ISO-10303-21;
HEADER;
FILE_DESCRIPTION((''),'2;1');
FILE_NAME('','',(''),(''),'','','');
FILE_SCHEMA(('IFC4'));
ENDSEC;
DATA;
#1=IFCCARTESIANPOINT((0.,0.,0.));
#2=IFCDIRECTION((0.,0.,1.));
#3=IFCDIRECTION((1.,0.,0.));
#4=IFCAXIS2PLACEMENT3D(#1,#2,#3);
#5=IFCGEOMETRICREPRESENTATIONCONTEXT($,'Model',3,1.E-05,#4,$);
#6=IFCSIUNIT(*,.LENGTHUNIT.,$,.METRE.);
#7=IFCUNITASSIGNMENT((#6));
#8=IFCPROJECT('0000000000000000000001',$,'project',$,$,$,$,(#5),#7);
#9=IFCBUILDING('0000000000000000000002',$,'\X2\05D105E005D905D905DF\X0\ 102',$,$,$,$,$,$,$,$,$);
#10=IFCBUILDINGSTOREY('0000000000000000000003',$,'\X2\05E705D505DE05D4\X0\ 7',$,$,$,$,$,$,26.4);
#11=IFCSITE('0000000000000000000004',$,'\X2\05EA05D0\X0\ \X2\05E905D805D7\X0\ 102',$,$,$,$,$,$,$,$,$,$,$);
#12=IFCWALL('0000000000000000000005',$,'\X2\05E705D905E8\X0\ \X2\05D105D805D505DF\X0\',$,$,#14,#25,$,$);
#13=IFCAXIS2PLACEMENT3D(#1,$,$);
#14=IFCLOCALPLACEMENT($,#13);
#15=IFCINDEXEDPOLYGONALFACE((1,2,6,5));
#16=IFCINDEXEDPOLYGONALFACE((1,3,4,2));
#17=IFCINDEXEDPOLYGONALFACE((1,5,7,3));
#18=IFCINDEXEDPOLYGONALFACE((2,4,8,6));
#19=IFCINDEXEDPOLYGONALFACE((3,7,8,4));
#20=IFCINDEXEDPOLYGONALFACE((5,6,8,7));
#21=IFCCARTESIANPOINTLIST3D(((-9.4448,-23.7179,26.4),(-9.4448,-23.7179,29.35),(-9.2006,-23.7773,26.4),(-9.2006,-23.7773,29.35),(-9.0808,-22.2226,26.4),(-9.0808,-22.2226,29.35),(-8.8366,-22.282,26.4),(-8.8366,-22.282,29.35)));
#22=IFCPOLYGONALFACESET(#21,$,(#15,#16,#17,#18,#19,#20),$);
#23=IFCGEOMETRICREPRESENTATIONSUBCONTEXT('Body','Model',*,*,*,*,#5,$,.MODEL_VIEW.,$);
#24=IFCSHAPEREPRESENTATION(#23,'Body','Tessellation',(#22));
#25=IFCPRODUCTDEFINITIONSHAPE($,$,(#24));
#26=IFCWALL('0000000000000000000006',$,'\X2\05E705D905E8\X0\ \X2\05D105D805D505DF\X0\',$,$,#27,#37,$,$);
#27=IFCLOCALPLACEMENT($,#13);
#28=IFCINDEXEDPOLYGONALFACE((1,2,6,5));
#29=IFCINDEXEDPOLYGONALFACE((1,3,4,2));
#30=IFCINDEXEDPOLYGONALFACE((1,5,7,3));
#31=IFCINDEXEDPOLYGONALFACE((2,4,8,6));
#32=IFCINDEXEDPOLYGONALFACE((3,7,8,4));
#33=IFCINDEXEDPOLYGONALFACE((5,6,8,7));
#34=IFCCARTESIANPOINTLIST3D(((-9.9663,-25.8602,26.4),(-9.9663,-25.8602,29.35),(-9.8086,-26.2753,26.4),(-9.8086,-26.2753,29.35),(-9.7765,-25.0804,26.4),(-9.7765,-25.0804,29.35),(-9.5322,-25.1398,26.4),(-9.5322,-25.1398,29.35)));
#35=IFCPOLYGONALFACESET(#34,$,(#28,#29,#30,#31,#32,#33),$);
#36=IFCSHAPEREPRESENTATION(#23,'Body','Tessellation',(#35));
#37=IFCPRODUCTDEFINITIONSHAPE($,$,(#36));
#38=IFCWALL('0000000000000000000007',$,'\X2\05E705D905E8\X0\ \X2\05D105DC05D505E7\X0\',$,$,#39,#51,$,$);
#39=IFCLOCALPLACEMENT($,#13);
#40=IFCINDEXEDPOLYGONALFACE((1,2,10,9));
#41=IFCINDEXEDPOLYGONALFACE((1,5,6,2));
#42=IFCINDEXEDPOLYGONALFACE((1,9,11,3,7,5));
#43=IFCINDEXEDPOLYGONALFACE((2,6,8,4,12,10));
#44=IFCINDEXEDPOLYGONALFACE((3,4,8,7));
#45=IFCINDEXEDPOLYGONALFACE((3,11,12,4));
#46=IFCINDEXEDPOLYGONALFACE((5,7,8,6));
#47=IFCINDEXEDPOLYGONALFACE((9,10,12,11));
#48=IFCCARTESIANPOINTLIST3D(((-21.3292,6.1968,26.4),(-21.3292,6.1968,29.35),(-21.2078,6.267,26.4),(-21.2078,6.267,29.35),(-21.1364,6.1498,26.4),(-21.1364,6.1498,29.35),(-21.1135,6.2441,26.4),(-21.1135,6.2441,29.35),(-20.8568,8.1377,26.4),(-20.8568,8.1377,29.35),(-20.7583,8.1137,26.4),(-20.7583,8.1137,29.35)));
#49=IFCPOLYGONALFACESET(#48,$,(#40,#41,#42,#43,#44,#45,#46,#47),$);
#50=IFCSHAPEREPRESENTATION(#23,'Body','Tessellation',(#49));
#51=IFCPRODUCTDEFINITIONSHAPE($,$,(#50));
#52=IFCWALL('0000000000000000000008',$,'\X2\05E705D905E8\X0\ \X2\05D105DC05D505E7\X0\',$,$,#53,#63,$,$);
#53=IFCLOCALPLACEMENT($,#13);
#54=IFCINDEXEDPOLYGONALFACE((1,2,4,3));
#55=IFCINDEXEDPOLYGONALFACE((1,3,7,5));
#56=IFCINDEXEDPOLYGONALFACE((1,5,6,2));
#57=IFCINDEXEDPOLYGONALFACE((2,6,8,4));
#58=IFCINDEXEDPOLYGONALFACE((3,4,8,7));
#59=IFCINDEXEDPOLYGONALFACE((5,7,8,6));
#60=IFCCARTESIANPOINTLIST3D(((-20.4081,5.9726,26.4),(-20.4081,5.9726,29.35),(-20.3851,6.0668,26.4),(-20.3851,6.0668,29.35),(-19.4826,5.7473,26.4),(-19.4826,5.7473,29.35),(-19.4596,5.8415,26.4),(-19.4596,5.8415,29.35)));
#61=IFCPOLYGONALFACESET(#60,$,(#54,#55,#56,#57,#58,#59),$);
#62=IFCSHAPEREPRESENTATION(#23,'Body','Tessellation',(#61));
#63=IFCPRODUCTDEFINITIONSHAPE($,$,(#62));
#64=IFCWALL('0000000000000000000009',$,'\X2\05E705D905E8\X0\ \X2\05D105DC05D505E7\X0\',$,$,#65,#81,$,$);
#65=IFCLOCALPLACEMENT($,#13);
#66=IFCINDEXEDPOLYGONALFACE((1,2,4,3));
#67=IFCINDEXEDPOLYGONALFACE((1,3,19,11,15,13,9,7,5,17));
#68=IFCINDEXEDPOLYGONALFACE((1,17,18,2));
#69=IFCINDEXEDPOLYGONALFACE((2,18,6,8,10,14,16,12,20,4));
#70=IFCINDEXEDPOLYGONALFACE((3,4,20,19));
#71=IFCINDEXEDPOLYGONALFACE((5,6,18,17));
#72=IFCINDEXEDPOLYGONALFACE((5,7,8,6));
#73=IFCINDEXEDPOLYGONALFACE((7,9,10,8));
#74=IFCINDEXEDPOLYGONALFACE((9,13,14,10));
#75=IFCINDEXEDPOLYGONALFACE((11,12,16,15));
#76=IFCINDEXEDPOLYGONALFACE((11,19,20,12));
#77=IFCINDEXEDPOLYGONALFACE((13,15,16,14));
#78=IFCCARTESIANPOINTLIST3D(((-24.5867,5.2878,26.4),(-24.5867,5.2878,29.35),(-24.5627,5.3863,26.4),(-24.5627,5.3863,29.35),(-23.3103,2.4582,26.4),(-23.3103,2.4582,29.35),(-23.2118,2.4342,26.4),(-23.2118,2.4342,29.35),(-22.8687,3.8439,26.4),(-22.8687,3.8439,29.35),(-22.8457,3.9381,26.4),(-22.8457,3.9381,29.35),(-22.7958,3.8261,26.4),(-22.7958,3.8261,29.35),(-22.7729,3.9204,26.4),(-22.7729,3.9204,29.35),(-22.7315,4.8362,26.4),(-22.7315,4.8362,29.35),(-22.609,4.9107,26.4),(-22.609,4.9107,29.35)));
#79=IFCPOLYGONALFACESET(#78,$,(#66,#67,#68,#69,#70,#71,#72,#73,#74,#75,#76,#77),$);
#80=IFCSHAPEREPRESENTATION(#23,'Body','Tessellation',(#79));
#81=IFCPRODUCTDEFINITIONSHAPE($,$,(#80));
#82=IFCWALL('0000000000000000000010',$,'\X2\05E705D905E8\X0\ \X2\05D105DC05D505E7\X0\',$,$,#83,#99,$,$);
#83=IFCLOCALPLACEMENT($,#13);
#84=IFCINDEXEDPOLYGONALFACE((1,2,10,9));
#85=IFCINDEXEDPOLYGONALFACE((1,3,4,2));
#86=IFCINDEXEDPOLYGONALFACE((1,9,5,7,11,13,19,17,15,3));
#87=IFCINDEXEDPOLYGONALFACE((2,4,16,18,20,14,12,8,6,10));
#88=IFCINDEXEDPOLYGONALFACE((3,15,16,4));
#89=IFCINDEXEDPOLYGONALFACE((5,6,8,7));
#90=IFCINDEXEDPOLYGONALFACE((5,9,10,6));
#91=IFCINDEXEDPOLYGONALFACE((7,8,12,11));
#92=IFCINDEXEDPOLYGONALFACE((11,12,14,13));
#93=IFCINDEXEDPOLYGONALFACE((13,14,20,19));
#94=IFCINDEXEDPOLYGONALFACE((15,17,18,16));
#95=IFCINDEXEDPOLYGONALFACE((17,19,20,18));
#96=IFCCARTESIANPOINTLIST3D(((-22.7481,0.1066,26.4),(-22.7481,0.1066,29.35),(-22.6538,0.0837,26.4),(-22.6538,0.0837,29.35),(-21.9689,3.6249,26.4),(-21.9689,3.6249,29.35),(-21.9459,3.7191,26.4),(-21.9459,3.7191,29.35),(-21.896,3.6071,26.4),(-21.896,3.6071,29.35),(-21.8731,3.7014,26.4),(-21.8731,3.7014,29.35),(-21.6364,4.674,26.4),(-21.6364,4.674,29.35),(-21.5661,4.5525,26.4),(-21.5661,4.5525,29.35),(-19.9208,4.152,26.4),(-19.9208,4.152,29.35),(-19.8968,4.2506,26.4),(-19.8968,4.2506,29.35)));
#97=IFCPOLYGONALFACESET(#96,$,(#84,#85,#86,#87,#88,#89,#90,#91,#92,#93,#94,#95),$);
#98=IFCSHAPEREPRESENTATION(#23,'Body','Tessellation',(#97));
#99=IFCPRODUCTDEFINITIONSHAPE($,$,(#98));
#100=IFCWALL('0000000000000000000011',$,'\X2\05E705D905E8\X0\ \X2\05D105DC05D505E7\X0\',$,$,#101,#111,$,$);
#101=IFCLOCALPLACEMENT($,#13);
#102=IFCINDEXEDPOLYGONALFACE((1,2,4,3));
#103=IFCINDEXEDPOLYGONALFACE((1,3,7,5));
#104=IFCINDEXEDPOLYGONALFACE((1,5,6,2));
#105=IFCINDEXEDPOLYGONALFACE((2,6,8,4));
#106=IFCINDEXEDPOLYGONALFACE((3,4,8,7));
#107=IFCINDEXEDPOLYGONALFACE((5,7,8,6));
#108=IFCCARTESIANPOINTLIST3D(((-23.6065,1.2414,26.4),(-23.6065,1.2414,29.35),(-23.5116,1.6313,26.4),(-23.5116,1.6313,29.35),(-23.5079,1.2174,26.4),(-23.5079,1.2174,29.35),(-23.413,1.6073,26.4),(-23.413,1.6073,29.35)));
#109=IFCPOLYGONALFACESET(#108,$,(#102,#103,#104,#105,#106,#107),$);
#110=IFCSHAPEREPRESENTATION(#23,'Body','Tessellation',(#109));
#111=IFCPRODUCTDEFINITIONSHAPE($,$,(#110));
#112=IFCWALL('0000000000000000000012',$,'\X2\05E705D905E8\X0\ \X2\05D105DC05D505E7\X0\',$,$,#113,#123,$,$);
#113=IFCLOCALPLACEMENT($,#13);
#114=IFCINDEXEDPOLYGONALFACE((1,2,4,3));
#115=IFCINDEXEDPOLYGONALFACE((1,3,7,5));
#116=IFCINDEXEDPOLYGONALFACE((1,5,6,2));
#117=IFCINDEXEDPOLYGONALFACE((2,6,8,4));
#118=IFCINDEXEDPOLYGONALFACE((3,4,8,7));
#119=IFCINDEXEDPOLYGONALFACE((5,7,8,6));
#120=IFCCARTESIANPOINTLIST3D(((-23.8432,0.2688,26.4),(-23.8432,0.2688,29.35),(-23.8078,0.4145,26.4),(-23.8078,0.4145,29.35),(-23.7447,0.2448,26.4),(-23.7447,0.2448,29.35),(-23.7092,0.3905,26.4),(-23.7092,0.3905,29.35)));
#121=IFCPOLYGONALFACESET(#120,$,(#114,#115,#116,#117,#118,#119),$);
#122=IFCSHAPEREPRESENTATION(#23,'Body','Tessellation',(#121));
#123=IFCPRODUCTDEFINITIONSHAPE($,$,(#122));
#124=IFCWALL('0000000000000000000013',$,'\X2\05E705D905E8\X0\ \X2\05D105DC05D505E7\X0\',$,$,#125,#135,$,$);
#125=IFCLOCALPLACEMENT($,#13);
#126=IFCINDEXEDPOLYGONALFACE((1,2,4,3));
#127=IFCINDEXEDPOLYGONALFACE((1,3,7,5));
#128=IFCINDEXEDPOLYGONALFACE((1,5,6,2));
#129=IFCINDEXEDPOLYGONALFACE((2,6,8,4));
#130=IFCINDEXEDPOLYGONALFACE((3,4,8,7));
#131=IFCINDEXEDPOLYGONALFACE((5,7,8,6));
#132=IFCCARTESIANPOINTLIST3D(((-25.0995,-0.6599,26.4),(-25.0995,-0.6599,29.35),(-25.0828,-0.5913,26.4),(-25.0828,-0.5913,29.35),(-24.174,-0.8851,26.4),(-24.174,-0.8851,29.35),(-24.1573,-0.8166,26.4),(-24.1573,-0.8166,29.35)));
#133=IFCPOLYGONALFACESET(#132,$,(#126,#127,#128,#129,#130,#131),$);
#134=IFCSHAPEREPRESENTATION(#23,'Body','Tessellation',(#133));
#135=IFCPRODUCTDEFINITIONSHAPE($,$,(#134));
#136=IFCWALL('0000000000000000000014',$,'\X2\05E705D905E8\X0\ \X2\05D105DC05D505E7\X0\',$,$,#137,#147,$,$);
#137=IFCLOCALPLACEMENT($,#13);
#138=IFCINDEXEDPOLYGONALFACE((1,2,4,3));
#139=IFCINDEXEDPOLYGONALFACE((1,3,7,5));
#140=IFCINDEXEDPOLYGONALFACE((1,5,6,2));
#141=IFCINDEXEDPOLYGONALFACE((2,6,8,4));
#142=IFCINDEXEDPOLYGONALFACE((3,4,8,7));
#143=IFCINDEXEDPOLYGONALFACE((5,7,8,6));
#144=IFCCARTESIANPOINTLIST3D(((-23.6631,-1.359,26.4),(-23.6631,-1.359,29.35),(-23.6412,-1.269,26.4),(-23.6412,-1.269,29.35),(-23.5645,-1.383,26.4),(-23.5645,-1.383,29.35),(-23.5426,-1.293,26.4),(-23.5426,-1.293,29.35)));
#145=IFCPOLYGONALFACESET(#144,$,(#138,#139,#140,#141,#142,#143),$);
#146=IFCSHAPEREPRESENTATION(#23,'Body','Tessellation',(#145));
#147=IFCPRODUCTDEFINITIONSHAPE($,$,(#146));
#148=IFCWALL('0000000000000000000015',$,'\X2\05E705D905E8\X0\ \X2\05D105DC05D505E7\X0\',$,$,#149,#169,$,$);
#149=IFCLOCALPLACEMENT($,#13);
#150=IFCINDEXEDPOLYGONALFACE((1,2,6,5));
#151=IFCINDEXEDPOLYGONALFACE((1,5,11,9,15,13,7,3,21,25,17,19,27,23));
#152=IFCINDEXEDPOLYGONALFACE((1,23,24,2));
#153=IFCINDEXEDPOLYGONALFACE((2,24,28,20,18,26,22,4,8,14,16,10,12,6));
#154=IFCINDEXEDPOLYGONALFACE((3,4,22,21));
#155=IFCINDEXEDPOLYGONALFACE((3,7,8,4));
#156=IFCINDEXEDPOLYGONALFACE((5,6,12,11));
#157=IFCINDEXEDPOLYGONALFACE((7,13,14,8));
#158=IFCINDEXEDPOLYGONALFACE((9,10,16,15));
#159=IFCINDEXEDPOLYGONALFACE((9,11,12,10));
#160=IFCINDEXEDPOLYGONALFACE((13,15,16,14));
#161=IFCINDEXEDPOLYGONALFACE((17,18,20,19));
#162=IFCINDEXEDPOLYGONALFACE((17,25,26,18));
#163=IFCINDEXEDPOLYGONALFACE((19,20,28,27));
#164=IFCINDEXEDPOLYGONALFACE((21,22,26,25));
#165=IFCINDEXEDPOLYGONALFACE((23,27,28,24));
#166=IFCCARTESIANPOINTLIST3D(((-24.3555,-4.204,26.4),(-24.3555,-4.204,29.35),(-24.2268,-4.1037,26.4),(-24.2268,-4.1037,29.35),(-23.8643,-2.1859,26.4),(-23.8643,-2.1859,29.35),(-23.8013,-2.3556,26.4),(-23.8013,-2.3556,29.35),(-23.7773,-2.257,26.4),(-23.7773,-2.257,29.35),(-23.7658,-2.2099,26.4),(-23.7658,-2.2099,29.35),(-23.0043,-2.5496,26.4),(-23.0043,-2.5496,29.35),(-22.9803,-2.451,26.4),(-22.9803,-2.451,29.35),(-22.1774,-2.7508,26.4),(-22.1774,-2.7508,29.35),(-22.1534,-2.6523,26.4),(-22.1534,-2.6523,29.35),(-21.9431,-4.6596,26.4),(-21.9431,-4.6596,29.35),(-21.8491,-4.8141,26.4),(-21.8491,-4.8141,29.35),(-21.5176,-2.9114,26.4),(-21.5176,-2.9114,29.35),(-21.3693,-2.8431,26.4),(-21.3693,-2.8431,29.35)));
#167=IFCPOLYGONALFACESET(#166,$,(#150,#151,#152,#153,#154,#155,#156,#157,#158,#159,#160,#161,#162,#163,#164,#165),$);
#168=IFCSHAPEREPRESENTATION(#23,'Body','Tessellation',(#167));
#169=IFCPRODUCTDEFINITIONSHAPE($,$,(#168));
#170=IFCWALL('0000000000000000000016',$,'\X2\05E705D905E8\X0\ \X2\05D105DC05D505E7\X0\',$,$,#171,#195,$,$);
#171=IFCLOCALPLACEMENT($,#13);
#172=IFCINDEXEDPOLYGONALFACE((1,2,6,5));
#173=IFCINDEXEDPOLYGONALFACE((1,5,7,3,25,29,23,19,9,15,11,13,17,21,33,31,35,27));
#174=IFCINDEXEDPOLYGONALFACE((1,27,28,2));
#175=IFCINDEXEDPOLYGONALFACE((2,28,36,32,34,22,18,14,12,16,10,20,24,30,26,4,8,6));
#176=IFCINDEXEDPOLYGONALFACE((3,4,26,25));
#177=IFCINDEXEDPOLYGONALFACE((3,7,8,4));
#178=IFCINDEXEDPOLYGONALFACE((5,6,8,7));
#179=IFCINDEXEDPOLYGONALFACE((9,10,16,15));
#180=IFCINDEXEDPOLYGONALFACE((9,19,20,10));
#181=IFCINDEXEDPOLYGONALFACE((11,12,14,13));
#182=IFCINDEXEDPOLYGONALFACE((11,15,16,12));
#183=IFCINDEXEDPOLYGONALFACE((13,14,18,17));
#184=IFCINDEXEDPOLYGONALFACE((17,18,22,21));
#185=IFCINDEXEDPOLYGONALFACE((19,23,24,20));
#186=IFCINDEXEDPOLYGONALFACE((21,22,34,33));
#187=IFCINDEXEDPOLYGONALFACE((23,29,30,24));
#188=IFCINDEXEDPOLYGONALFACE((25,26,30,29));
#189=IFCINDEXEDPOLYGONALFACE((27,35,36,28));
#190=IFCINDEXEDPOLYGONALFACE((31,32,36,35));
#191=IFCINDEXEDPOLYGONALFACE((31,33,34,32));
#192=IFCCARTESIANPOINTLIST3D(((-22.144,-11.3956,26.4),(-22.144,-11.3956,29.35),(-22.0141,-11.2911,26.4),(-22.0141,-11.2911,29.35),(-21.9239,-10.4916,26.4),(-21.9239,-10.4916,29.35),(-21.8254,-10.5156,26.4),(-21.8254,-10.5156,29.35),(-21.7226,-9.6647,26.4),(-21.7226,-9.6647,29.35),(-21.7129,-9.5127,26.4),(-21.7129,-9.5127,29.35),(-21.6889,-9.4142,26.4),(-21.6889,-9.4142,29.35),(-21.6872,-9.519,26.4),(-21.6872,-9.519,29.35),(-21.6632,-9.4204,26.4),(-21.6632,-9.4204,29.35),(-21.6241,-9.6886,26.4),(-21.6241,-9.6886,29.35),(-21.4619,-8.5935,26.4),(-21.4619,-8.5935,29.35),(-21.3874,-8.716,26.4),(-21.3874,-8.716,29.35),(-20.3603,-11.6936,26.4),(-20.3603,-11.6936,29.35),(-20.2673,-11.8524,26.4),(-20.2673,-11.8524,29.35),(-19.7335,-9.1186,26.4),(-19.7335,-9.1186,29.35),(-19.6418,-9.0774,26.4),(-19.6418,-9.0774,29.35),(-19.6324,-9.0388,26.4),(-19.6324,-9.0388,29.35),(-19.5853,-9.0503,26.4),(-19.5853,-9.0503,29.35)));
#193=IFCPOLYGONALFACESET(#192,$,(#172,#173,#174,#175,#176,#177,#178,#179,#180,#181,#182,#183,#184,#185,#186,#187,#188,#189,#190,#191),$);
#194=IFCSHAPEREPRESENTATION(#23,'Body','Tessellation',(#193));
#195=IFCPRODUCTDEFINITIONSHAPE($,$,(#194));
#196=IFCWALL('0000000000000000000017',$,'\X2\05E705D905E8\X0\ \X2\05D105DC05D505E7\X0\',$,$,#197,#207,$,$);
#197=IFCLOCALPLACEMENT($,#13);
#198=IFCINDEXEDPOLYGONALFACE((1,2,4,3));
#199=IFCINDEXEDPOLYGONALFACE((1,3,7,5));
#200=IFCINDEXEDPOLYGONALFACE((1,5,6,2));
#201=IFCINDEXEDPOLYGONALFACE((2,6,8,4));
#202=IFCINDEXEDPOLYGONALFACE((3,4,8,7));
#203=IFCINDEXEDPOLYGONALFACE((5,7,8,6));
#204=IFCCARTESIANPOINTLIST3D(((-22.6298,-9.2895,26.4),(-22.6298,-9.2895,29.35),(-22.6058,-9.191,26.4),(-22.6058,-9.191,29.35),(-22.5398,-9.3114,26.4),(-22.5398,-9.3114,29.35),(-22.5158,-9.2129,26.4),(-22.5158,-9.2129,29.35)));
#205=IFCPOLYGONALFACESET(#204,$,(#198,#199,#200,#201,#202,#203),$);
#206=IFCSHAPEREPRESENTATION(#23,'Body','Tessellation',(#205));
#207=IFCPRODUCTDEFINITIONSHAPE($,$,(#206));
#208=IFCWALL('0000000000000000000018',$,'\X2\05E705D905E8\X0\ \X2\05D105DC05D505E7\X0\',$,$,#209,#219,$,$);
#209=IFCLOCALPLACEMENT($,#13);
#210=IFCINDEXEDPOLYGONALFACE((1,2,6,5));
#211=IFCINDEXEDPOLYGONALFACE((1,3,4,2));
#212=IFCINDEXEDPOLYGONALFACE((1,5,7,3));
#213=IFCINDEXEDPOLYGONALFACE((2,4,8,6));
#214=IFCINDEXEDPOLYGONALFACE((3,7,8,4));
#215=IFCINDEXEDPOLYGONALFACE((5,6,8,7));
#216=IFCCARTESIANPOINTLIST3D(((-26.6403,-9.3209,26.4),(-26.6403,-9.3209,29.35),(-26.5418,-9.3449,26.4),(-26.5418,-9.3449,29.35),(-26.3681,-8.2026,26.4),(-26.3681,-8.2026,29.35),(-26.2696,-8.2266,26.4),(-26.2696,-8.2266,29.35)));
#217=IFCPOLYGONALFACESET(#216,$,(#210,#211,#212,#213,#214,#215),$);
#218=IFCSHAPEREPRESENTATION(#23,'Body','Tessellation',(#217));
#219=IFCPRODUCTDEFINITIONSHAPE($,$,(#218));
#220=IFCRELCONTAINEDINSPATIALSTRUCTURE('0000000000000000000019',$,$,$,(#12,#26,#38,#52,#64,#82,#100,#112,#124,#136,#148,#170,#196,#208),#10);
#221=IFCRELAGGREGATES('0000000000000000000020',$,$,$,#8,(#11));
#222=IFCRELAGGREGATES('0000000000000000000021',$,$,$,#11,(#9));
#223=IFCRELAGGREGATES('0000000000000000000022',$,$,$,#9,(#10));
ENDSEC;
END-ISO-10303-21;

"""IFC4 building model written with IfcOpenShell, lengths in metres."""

from ifc_helpers import new_model, si_unit, frame, origin_with_axes, context, subcontext, project, spatial, polyline, outline, extrude, element, save


model = new_model("IFC4")

# Units and contexts
model_context = context("Model", 3, precision=1e-05, world=origin_with_axes())
body_context = subcontext(model_context, "Body", "Model", "MODEL_VIEW")
ifc_project = project(units=[si_unit("LENGTHUNIT", "METRE")], contexts=[model_context])

# Site, building, storey
site = spatial("IfcSite", under=ifc_project, Name="תא שטח 102")
building = spatial("IfcBuilding", under=site, Name="בניין 102")
storey = spatial("IfcBuildingStorey", under=building, Name="קומה 7", Elevation=26.4)

# Walls
element("IfcWall", 1, inside=storey, Name="קיר בטון", context=body_context, shape_type="SweptSolid", body=[
    extrude(outline(polyline([(-9.4448, -23.7179), (-9.2006, -23.7773), (-8.8366, -22.282), (-9.0808, -22.2226), (-9.4448, -23.7179)])), frame((0.0, 0.0, 26.4)), (0.0, 0.0, 1.0), 2.95),
])
element("IfcWall", 2, inside=storey, Name="קיר בטון", context=body_context, shape_type="SweptSolid", body=[
    extrude(outline(polyline([(-9.9663, -25.8602), (-9.8086, -26.2753), (-9.5322, -25.1398), (-9.7765, -25.0804), (-9.9663, -25.8602)])), frame((0.0, 0.0, 26.4)), (0.0, 0.0, 1.0), 2.95),
])
element("IfcWall", 3, inside=storey, Name="קיר בלוק", context=body_context, shape_type="SweptSolid", body=[
    extrude(outline(polyline([(-21.1135, 6.2441), (-21.2078, 6.267), (-20.7583, 8.1137), (-20.8568, 8.1377), (-21.3292, 6.1968), (-21.1364, 6.1498), (-21.1135, 6.2441)])), frame((0.0, 0.0, 26.4)), (0.0, 0.0, 1.0), 2.95),
])
element("IfcWall", 4, inside=storey, Name="קיר בלוק", context=body_context, shape_type="SweptSolid", body=[
    extrude(outline(polyline([(-19.4596, 5.8415), (-20.3851, 6.0668), (-20.4081, 5.9726), (-19.4826, 5.7473), (-19.4596, 5.8415)])), frame((0.0, 0.0, 26.4)), (0.0, 0.0, 1.0), 2.95),
])
element("IfcWall", 5, inside=storey, Name="קיר בלוק", context=body_context, shape_type="SweptSolid", body=[
    extrude(outline(polyline([(-23.3103, 2.4582), (-23.2118, 2.4342), (-22.8687, 3.8439), (-22.7958, 3.8261), (-22.7729, 3.9204), (-22.8457, 3.9381), (-22.609, 4.9107), (-24.5627, 5.3863), (-24.5867, 5.2878), (-22.7315, 4.8362), (-23.3103, 2.4582)])), frame((0.0, 0.0, 26.4)), (0.0, 0.0, 1.0), 2.95),
])
element("IfcWall", 6, inside=storey, Name="קיר בלוק", context=body_context, shape_type="SweptSolid", body=[
    extrude(outline(polyline([(-21.9689, 3.6249), (-21.896, 3.6071), (-22.7481, 0.1066), (-22.6538, 0.0837), (-21.5661, 4.5525), (-19.9208, 4.152), (-19.8968, 4.2506), (-21.6364, 4.674), (-21.8731, 3.7014), (-21.9459, 3.7191), (-21.9689, 3.6249)])), frame((0.0, 0.0, 26.4)), (0.0, 0.0, 1.0), 2.95),
])
element("IfcWall", 7, inside=storey, Name="קיר בלוק", context=body_context, shape_type="SweptSolid", body=[
    extrude(outline(polyline([(-23.413, 1.6073), (-23.5116, 1.6313), (-23.6065, 1.2414), (-23.5079, 1.2174), (-23.413, 1.6073)])), frame((0.0, 0.0, 26.4)), (0.0, 0.0, 1.0), 2.95),
])
element("IfcWall", 8, inside=storey, Name="קיר בלוק", context=body_context, shape_type="SweptSolid", body=[
    extrude(outline(polyline([(-23.8078, 0.4145), (-23.8432, 0.2688), (-23.7447, 0.2448), (-23.7092, 0.3905), (-23.8078, 0.4145)])), frame((0.0, 0.0, 26.4)), (0.0, 0.0, 1.0), 2.95),
])
element("IfcWall", 9, inside=storey, Name="קיר בלוק", context=body_context, shape_type="SweptSolid", body=[
    extrude(outline(polyline([(-25.0828, -0.5913), (-25.0995, -0.6599), (-24.174, -0.8851), (-24.1573, -0.8166), (-25.0828, -0.5913)])), frame((0.0, 0.0, 26.4)), (0.0, 0.0, 1.0), 2.95),
])
element("IfcWall", 10, inside=storey, Name="קיר בלוק", context=body_context, shape_type="SweptSolid", body=[
    extrude(outline(polyline([(-23.5426, -1.293), (-23.6412, -1.269), (-23.6631, -1.359), (-23.5645, -1.383), (-23.5426, -1.293)])), frame((0.0, 0.0, 26.4)), (0.0, 0.0, 1.0), 2.95),
])
element("IfcWall", 11, inside=storey, Name="קיר בלוק", context=body_context, shape_type="SweptSolid", body=[
    extrude(outline(polyline([(-24.2268, -4.1037), (-23.8013, -2.3556), (-23.0043, -2.5496), (-22.9803, -2.451), (-23.7773, -2.257), (-23.7658, -2.2099), (-23.8643, -2.1859), (-24.3555, -4.204), (-21.8491, -4.8141), (-21.3693, -2.8431), (-22.1534, -2.6523), (-22.1774, -2.7508), (-21.5176, -2.9114), (-21.9431, -4.6596), (-24.2268, -4.1037)])), frame((0.0, 0.0, 26.4)), (0.0, 0.0, 1.0), 2.95),
])
element("IfcWall", 12, inside=storey, Name="קיר בלוק", context=body_context, shape_type="SweptSolid", body=[
    extrude(outline(polyline([(-21.7129, -9.5127), (-21.6872, -9.519), (-21.7226, -9.6647), (-21.6241, -9.6886), (-21.3874, -8.716), (-19.7335, -9.1186), (-20.3603, -11.6936), (-22.0141, -11.2911), (-21.8254, -10.5156), (-21.9239, -10.4916), (-22.144, -11.3956), (-20.2673, -11.8524), (-19.5853, -9.0503), (-19.6418, -9.0774), (-19.6324, -9.0388), (-21.4619, -8.5935), (-21.6632, -9.4204), (-21.6889, -9.4142), (-21.7129, -9.5127)])), frame((0.0, 0.0, 26.4)), (0.0, 0.0, 1.0), 2.95),
])
element("IfcWall", 13, inside=storey, Name="קיר בלוק", context=body_context, shape_type="SweptSolid", body=[
    extrude(outline(polyline([(-22.6058, -9.191), (-22.6298, -9.2895), (-22.5398, -9.3114), (-22.5158, -9.2129), (-22.6058, -9.191)])), frame((0.0, 0.0, 26.4)), (0.0, 0.0, 1.0), 2.95),
])
element("IfcWall", 14, inside=storey, Name="קיר בלוק", context=body_context, shape_type="SweptSolid", body=[
    extrude(outline(polyline([(-26.6403, -9.3209), (-26.5418, -9.3449), (-26.2696, -8.2266), (-26.3681, -8.2026), (-26.6403, -9.3209)])), frame((0.0, 0.0, 26.4)), (0.0, 0.0, 1.0), 2.95),
])

save(model, "model.ifc")
